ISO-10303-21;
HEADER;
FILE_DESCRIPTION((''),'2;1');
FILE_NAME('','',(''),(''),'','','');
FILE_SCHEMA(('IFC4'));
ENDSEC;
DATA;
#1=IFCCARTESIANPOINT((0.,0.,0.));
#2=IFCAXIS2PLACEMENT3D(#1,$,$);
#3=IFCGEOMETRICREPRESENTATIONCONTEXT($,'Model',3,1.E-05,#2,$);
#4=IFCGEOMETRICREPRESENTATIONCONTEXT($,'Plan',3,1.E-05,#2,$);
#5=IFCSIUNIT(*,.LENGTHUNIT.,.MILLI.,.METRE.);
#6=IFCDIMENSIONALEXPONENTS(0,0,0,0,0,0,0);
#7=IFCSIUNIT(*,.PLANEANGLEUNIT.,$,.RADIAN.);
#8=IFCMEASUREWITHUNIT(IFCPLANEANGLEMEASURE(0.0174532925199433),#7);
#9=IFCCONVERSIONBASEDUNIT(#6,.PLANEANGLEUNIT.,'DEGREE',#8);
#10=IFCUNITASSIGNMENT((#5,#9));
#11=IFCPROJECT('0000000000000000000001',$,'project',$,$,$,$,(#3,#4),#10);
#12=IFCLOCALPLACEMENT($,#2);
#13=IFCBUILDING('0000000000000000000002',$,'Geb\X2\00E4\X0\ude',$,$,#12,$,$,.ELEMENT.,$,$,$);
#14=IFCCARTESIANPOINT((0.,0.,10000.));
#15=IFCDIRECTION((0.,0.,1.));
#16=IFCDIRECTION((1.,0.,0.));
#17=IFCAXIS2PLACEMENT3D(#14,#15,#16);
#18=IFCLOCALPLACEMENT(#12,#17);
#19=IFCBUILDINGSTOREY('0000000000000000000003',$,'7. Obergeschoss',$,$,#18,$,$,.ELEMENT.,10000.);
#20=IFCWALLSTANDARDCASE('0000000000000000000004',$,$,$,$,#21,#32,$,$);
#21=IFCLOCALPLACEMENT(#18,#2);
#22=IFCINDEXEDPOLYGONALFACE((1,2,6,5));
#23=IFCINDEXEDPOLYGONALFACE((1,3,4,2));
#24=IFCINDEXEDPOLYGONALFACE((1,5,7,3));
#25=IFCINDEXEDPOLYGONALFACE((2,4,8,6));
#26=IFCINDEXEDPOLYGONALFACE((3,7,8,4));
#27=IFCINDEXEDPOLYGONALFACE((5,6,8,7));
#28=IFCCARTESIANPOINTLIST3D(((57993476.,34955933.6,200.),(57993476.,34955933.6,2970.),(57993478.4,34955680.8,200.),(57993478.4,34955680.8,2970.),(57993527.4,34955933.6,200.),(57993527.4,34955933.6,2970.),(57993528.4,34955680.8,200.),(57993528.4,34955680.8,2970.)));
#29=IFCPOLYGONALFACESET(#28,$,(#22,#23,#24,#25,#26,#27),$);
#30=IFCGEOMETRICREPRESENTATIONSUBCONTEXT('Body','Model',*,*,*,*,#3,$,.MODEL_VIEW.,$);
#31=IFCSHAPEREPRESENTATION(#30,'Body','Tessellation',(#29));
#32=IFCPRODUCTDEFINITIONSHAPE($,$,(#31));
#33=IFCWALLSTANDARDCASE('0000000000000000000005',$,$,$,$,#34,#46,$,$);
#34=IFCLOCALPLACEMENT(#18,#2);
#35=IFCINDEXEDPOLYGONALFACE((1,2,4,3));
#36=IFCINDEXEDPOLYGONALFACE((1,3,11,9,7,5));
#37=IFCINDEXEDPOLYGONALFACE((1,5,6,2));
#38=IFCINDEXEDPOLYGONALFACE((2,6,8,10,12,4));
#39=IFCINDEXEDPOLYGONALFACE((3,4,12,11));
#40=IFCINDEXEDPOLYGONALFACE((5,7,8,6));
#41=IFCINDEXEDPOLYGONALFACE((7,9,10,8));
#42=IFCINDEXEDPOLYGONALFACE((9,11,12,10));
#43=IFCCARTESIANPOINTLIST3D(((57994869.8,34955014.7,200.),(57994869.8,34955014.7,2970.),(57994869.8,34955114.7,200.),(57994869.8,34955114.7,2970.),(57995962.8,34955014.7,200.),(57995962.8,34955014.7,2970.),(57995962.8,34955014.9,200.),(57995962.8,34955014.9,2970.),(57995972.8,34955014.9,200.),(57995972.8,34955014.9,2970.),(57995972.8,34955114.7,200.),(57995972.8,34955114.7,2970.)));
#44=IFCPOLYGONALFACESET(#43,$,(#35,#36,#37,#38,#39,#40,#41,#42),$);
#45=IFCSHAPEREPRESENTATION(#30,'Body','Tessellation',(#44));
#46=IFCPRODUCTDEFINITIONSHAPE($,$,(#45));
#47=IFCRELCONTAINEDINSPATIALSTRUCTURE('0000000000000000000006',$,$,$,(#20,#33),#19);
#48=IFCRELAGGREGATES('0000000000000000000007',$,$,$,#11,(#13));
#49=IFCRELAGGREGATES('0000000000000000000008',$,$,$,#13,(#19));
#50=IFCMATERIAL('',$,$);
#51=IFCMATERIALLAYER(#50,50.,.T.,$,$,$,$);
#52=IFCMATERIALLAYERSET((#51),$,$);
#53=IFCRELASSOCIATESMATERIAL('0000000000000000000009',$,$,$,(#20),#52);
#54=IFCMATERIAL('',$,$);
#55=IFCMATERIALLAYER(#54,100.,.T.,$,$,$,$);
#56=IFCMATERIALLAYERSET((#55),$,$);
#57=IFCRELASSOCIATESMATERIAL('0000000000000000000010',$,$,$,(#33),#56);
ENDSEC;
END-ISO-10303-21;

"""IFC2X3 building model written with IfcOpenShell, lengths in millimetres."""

from ifc_helpers import new_model, entity, si_unit, converted_unit, frame, origin, origin_with_axes, place, context, subcontext, project, spatial, polyline, outline, extrude, material, layer, layer_set, layer_usage, element, save


model = new_model("IFC2X3")

# Units and contexts
model_context = context("Model", 3, precision=1e-05, world=origin())
plan_context = context("Plan", 3, precision=1e-05, world=origin())
body_context = subcontext(model_context, "Body", "Model", "MODEL_VIEW")
ifc_project = project(units=[si_unit("LENGTHUNIT", "METRE", prefix="MILLI"), converted_unit("PLANEANGLEUNIT", "DEGREE", entity("IfcPlaneAngleMeasure", 0.0174532925199433), si_unit("PLANEANGLEUNIT", "RADIAN"), dimensions=[0, 0, 0, 0, 0, 0, 0])], contexts=[model_context, plan_context])

# Building, storey
building_placement = place(None, origin())
building = spatial("IfcBuilding", under=ifc_project, at=building_placement, Name="Gebäude", CompositionType="ELEMENT")
storey_placement = place(building_placement, frame((0.0, 0.0, 10000.0), z_axis=(0.0, 0.0, 1.0), x_axis=(1.0, 0.0, 0.0)))
storey = spatial("IfcBuildingStorey", under=building, at=storey_placement, Name="7. Obergeschoss", CompositionType="ELEMENT", Elevation=10000.0)

# Walls
ifc_material_1 = material(Name="")
ifc_layer_1 = layer(ifc_material_1, 50.0, ventilated=True)
ifc_layer_set_1 = layer_set([ifc_layer_1])
ifc_layer_usage_1 = layer_usage(ifc_layer_set_1, "AXIS2", "POSITIVE", 0.0)
wall_1_placement = place(storey_placement, frame((57993476.0, 34955933.6, 200.0), z_axis=(0.0, 0.0, 1.0), x_axis=(0.009735, -0.999953, 0.0)))
element("IfcWallStandardCase", 1, at=wall_1_placement, inside=storey, material=ifc_layer_usage_1, context=body_context, shape_type="SweptSolid", body=[
    extrude(outline(polyline([(0.0, 0.0), (252.8, 0.0), (253.2, 50.0), (0.5, 51.5), (0.0, 0.0)])), origin_with_axes(), (0.0, 0.0, 1.0), 2770.0),
])
ifc_material_2 = material(Name="")
ifc_layer_2 = layer(ifc_material_2, 100.0, ventilated=True)
ifc_layer_set_2 = layer_set([ifc_layer_2])
ifc_layer_usage_2 = layer_usage(ifc_layer_set_2, "AXIS2", "POSITIVE", 0.0)
wall_2_placement = place(storey_placement, frame((57994869.8, 34955014.7, 200.0), z_axis=(0.0, 0.0, 1.0), x_axis=(1.0, 0.0, 0.0)))
element("IfcWallStandardCase", 2, at=wall_2_placement, inside=storey, material=ifc_layer_usage_2, context=body_context, shape_type="SweptSolid", body=[
    extrude(outline(polyline([(0.0, 0.0), (1093.0, 0.0), (1093.0, 0.2), (1103.0, 0.2), (1103.0, 100.0), (0.0, 100.0), (0.0, 0.0)])), origin_with_axes(), (0.0, 0.0, 1.0), 2770.0),
])

save(model, "model.ifc")
